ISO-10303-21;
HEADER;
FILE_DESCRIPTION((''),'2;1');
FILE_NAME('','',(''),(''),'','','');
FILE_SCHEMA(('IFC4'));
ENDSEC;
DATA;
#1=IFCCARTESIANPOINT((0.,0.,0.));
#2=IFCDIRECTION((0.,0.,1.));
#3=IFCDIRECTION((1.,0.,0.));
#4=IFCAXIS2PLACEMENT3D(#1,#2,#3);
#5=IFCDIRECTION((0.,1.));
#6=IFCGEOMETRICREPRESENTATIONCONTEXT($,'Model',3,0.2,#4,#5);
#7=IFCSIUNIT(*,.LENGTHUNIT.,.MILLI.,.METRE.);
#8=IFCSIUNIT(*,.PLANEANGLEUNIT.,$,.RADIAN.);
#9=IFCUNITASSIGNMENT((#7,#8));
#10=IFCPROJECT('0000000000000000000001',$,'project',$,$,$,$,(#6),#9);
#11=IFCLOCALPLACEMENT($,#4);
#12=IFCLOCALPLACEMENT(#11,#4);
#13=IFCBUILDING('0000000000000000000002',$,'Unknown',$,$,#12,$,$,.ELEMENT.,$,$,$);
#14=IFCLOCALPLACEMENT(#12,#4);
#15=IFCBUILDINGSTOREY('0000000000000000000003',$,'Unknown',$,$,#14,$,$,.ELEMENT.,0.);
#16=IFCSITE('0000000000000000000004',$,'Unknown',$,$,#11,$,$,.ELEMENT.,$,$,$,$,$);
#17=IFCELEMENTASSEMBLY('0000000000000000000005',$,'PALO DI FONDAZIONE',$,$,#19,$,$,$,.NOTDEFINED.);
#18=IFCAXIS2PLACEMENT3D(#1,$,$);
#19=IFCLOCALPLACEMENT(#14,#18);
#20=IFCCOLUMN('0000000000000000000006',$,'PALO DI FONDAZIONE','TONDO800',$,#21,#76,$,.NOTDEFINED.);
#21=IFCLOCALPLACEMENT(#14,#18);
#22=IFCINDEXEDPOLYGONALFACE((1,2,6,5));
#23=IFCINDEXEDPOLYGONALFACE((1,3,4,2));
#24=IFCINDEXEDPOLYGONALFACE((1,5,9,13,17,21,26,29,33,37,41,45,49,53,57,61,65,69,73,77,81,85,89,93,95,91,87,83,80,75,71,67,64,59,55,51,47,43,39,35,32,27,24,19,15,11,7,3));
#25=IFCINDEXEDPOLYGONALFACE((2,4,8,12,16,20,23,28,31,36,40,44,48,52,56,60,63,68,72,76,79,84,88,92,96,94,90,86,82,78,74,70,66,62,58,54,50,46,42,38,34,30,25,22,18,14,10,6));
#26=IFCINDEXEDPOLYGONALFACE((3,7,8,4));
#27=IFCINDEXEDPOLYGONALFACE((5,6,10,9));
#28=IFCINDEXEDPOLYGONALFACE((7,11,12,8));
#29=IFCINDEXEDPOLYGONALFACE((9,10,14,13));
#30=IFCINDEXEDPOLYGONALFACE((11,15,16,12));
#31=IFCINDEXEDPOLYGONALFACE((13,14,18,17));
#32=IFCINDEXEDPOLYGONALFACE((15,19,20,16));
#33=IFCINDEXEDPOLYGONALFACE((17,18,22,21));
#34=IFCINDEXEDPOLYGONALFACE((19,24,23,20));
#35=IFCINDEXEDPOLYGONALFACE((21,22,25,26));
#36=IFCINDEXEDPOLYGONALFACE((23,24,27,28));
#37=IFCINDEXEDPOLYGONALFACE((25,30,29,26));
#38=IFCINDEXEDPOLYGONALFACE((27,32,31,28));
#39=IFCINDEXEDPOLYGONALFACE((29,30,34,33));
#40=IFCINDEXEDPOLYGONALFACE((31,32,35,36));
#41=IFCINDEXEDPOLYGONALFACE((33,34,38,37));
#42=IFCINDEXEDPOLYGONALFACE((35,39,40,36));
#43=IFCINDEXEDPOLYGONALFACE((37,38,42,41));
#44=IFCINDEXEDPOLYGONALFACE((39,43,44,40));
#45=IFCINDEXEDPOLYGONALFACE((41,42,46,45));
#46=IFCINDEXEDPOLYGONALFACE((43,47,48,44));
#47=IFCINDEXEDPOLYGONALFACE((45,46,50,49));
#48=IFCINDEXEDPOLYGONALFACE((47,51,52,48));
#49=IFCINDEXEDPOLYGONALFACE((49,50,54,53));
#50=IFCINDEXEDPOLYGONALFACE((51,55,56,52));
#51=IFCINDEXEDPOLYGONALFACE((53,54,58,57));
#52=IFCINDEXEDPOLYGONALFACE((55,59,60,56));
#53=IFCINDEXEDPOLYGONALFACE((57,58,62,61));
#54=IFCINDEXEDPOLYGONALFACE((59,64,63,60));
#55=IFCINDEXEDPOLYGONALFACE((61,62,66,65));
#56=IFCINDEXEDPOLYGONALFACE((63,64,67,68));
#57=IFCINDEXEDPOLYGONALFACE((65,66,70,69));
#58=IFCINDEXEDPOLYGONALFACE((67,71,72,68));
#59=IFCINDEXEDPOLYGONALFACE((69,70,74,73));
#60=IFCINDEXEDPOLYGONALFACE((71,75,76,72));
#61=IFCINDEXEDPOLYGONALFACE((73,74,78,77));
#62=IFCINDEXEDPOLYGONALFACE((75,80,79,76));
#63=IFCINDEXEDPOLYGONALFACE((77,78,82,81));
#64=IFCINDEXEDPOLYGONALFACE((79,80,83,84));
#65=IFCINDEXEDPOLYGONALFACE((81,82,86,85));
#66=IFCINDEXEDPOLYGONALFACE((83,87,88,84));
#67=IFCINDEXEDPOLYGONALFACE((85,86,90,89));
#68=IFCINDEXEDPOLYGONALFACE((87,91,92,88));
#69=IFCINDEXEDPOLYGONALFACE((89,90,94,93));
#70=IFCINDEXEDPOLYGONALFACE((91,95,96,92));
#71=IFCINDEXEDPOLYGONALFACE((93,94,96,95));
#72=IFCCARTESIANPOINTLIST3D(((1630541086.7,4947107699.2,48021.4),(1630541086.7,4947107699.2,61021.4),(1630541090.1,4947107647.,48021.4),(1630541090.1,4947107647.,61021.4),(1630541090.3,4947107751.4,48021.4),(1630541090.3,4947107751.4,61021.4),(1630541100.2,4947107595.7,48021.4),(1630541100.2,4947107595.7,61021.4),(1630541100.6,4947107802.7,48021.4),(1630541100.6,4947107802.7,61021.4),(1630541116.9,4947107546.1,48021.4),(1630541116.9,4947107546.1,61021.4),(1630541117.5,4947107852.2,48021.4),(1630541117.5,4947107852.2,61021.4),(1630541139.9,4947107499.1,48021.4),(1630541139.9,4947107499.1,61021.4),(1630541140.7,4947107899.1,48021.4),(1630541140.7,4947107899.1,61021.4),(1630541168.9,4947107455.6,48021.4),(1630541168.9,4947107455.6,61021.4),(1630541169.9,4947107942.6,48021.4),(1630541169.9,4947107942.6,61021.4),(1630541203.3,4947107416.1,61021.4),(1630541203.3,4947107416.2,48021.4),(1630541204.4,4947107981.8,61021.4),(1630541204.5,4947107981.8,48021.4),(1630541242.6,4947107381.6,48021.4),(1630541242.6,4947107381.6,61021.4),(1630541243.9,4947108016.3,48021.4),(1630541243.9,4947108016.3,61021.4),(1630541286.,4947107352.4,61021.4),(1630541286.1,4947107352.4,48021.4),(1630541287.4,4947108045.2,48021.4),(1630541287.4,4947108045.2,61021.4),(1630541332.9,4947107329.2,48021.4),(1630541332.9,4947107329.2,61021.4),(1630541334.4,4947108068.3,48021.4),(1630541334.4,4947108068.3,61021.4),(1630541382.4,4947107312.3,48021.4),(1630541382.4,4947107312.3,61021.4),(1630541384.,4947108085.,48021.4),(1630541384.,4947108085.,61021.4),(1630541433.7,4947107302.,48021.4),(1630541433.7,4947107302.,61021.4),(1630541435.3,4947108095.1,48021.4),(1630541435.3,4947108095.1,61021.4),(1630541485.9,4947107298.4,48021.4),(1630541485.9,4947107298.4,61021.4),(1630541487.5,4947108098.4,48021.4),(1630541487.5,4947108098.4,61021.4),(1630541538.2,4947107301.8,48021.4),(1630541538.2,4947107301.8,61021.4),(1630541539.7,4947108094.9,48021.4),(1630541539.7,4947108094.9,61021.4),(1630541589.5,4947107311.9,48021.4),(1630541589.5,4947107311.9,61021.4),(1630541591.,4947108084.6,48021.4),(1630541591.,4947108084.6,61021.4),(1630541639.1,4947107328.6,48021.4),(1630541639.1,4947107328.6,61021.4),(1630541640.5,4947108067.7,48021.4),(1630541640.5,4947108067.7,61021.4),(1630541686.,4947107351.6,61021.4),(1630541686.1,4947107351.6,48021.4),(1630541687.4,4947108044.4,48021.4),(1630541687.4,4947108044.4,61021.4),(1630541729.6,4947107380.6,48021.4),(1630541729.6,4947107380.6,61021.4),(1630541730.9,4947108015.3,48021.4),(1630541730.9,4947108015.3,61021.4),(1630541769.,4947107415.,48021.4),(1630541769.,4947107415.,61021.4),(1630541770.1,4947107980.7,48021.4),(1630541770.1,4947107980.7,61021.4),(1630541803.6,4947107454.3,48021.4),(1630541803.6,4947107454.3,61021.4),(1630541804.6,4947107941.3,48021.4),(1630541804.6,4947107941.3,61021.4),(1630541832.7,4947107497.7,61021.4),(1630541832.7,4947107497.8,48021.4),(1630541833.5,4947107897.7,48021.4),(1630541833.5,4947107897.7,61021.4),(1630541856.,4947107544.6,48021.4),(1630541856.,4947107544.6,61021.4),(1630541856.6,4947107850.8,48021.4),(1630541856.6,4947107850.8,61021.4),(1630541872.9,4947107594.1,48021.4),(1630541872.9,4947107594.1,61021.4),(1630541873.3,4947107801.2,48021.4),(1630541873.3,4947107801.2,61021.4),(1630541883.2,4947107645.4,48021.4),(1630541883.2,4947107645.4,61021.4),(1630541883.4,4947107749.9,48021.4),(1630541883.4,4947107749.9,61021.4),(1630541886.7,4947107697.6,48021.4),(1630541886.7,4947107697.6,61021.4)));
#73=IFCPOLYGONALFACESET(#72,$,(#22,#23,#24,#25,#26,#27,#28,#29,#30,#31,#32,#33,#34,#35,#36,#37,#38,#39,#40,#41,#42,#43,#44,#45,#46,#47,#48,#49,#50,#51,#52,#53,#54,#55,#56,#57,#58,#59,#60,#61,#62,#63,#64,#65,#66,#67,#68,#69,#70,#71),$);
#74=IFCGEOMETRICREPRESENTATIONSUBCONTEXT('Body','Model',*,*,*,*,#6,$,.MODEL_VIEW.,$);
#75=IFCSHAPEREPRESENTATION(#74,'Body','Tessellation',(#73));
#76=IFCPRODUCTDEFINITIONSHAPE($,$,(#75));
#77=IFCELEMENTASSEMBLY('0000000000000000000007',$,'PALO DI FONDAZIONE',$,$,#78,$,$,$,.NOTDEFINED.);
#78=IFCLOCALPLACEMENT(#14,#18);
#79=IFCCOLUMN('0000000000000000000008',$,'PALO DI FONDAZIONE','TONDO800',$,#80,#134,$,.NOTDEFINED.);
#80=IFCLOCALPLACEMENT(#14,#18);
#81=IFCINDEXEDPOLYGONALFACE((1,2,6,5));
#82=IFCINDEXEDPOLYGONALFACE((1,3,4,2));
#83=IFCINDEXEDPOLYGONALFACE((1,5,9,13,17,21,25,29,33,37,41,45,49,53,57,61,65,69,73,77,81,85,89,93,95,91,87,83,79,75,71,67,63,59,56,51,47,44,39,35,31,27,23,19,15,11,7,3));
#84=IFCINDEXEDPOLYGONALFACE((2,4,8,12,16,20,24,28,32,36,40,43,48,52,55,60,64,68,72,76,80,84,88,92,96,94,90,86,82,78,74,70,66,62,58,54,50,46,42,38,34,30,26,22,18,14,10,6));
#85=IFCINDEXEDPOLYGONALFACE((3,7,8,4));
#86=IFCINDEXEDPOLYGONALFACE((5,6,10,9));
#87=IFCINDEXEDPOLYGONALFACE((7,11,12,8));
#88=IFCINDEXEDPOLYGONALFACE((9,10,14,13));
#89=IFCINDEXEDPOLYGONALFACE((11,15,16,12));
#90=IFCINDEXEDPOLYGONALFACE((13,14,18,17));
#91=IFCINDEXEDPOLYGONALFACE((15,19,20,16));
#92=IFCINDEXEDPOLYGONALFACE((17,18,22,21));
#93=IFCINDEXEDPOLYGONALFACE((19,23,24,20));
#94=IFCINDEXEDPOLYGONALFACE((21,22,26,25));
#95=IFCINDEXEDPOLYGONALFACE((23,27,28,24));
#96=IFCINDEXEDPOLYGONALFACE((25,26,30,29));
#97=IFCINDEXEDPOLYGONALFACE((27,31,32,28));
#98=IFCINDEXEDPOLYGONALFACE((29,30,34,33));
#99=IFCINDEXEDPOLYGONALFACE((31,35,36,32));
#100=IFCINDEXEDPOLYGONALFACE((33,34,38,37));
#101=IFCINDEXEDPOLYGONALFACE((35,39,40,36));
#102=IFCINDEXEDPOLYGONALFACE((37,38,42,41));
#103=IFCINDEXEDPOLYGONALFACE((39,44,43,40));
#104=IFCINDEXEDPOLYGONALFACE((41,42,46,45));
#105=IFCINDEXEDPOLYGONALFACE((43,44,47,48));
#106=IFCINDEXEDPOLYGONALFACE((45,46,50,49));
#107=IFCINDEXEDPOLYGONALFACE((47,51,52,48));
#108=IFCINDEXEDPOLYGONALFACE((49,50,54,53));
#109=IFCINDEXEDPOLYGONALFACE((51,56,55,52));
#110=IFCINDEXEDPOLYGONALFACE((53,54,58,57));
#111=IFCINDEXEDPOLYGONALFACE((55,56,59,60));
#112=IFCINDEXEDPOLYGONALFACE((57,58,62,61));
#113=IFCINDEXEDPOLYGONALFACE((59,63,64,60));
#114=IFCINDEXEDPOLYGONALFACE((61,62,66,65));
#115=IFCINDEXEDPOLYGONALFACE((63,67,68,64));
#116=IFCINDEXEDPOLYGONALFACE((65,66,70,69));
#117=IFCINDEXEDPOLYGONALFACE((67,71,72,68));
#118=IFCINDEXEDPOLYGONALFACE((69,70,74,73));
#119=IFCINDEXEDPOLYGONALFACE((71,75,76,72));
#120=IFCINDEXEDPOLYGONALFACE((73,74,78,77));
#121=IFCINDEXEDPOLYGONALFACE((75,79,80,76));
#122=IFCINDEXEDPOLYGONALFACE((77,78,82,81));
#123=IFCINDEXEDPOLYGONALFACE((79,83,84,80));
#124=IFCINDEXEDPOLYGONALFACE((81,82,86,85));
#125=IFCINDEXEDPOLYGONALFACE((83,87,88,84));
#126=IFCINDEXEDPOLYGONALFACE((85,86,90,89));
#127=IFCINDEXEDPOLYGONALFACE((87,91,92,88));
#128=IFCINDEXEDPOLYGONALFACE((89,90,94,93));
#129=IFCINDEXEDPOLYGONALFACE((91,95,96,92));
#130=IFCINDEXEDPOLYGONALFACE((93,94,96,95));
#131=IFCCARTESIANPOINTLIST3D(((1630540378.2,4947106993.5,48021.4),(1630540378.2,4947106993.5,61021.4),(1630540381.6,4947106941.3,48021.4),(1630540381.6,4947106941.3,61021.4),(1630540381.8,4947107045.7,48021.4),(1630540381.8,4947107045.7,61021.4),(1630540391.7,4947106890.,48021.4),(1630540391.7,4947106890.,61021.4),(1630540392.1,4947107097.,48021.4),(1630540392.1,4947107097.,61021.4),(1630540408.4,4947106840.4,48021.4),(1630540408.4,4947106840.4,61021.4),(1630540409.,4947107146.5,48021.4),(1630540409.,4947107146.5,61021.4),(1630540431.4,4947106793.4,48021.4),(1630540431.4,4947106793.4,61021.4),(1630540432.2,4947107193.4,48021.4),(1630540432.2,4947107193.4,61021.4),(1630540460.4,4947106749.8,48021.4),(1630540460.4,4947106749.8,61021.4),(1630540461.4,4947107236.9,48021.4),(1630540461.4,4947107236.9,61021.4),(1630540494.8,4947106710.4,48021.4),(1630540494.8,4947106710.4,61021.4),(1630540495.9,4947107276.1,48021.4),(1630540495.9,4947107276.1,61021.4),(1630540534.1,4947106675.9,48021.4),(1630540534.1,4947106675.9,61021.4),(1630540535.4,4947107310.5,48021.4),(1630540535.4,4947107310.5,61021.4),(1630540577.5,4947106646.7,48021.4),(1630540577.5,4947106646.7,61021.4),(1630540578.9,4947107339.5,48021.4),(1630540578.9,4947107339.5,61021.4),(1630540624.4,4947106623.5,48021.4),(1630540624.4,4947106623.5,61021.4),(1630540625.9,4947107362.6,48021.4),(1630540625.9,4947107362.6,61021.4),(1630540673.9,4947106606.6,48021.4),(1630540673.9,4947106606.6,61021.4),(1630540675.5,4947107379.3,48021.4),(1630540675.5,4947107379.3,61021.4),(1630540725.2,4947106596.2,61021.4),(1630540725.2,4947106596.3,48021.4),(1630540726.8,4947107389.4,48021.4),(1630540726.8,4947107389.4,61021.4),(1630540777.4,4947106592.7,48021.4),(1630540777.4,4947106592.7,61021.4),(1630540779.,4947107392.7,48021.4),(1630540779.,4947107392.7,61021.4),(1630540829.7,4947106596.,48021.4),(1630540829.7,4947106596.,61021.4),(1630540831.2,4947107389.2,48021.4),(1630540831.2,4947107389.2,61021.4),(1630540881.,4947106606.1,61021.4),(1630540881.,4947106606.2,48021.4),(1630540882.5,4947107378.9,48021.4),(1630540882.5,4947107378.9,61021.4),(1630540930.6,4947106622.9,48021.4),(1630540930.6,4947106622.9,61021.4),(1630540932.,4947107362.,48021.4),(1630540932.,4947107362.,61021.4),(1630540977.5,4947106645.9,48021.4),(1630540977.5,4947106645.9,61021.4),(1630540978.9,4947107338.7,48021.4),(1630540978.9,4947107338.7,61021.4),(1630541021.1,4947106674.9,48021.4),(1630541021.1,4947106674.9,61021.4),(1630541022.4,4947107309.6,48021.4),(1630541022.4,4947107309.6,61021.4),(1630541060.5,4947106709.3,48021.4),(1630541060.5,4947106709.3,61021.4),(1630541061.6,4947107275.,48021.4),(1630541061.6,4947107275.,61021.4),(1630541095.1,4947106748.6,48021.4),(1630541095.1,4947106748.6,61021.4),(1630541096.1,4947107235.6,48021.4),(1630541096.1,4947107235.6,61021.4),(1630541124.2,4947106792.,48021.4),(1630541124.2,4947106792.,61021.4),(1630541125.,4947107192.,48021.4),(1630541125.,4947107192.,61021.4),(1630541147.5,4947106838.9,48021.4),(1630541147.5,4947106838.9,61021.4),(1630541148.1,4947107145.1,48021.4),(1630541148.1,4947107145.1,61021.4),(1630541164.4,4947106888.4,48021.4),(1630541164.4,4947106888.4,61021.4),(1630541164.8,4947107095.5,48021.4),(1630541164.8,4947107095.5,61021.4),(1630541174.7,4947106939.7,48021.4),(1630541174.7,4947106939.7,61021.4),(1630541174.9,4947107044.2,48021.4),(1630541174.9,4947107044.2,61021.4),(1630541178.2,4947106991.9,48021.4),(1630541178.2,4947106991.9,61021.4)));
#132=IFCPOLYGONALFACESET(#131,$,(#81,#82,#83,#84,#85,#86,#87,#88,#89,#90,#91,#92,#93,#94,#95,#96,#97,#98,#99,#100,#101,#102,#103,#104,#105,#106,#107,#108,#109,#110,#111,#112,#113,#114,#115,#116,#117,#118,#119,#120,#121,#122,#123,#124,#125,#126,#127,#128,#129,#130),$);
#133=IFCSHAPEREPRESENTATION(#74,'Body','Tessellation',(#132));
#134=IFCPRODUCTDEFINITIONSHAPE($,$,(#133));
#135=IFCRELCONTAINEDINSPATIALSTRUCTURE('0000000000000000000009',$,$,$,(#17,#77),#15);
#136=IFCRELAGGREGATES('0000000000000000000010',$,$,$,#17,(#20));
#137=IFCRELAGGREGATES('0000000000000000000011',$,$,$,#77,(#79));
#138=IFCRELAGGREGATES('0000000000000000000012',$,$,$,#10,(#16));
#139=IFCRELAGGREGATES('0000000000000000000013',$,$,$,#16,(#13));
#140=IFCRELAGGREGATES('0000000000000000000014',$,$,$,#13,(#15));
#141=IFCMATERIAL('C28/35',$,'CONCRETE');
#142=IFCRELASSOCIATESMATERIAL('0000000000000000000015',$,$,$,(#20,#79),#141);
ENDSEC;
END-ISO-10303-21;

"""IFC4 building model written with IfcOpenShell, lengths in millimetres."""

from ifc_helpers import new_model, si_unit, direction, frame, origin_with_axes, place, context, subcontext, project, spatial, line, indexed_curve, outline, extrude, material, element, aggregate, save


model = new_model("IFC4")

# Units and contexts
model_context = context("Model", 3, precision=0.2, world=origin_with_axes(), true_north=direction((0.0, 1.0)))
body_context = subcontext(model_context, "Body", "Model", "MODEL_VIEW")
ifc_project = project(units=[si_unit("LENGTHUNIT", "METRE", prefix="MILLI"), si_unit("PLANEANGLEUNIT", "RADIAN")], contexts=[model_context])

# Site, building, storey
site_placement = place(None, origin_with_axes())
site = spatial("IfcSite", under=ifc_project, at=site_placement, Name="Unknown", CompositionType="ELEMENT")
building_placement = place(site_placement, origin_with_axes())
building = spatial("IfcBuilding", under=site, at=building_placement, Name="Unknown", CompositionType="ELEMENT")
storey_placement = place(building_placement, origin_with_axes())
storey = spatial("IfcBuildingStorey", under=building, at=storey_placement, Name="Unknown", CompositionType="ELEMENT", Elevation=0.0)

# Element assemblies, columns
ifc_material_1 = material(Name="C28/35", Category="CONCRETE")
assembly_1_placement = place(storey_placement, frame((1630541486.7, 4947107698.4, 48021.4), z_axis=(0.705709, -0.708501, 0.0), x_axis=(0.0, 0.0, 1.0)))
assembly_1 = element("IfcElementAssembly", 1, at=assembly_1_placement, inside=storey, Name="PALO DI FONDAZIONE", PredefinedType="NOTDEFINED")
column_1_placement = place(assembly_1_placement, origin_with_axes())
column_1 = element("IfcColumn", 2, at=column_1_placement, material=ifc_material_1, Name="PALO DI FONDAZIONE", Description="TONDO800", PredefinedType="NOTDEFINED", context=body_context, shape_type="SolidModel", body=[
    extrude(outline(indexed_curve([(400.0, 0.0), (396.6, 52.2), (386.4, 103.5), (369.6, 153.1), (346.4, 200.0), (317.3, 243.5), (282.8, 282.8), (243.5, 317.3), (200.0, 346.4), (153.1, 369.6), (103.5, 386.4), (52.2, 396.6), (0.0, 400.0), (-52.2, 396.6), (-103.5, 386.4), (-153.1, 369.6), (-200.0, 346.4), (-243.5, 317.3), (-282.8, 282.8), (-317.3, 243.5), (-346.4, 200.0), (-369.6, 153.1), (-386.4, 103.5), (-396.6, 52.2), (-400.0, 0.0), (-396.6, -52.2), (-386.4, -103.5), (-369.6, -153.1), (-346.4, -200.0), (-317.3, -243.5), (-282.8, -282.8), (-243.5, -317.3), (-200.0, -346.4), (-153.1, -369.6), (-103.5, -386.4), (-52.2, -396.6), (0.0, -400.0), (52.2, -396.6), (103.5, -386.4), (153.1, -369.6), (200.0, -346.4), (243.5, -317.3), (282.8, -282.8), (317.3, -243.5), (346.4, -200.0), (369.6, -153.1), (386.4, -103.5), (396.6, -52.2)], segments=[line(1, 2, 3, 4, 5, 6, 7, 8, 9, 10, 11, 12, 13, 14, 15, 16, 17, 18, 19, 20, 21, 22, 23, 24, 25, 26, 27, 28, 29, 30, 31, 32, 33, 34, 35, 36, 37, 38, 39, 40, 41, 42, 43, 44, 45, 46, 47, 48, 1)])), frame((0.0, 0.0, 0.0), z_axis=(-1.0, 0.0, 0.0), x_axis=(0.0, 0.0, 1.0)), (0.0, 0.0, -1.0), 13000.0),
])
aggregate(assembly_1, [column_1])
assembly_2_placement = place(storey_placement, frame((1630540778.2, 4947106992.7, 48021.4), z_axis=(0.705709, -0.708501, 0.0), x_axis=(0.0, 0.0, 1.0)))
assembly_2 = element("IfcElementAssembly", 3, at=assembly_2_placement, inside=storey, Name="PALO DI FONDAZIONE", PredefinedType="NOTDEFINED")
column_2_placement = place(assembly_2_placement, origin_with_axes())
column_2 = element("IfcColumn", 4, at=column_2_placement, material=ifc_material_1, Name="PALO DI FONDAZIONE", Description="TONDO800", PredefinedType="NOTDEFINED", context=body_context, shape_type="SolidModel", body=[
    extrude(outline(indexed_curve([(400.0, 0.0), (396.6, 52.2), (386.4, 103.5), (369.6, 153.1), (346.4, 200.0), (317.3, 243.5), (282.8, 282.8), (243.5, 317.3), (200.0, 346.4), (153.1, 369.6), (103.5, 386.4), (52.2, 396.6), (0.0, 400.0), (-52.2, 396.6), (-103.5, 386.4), (-153.1, 369.6), (-200.0, 346.4), (-243.5, 317.3), (-282.8, 282.8), (-317.3, 243.5), (-346.4, 200.0), (-369.6, 153.1), (-386.4, 103.5), (-396.6, 52.2), (-400.0, 0.0), (-396.6, -52.2), (-386.4, -103.5), (-369.6, -153.1), (-346.4, -200.0), (-317.3, -243.5), (-282.8, -282.8), (-243.5, -317.3), (-200.0, -346.4), (-153.1, -369.6), (-103.5, -386.4), (-52.2, -396.6), (0.0, -400.0), (52.2, -396.6), (103.5, -386.4), (153.1, -369.6), (200.0, -346.4), (243.5, -317.3), (282.8, -282.8), (317.3, -243.5), (346.4, -200.0), (369.6, -153.1), (386.4, -103.5), (396.6, -52.2)], segments=[line(1, 2, 3, 4, 5, 6, 7, 8, 9, 10, 11, 12, 13, 14, 15, 16, 17, 18, 19, 20, 21, 22, 23, 24, 25, 26, 27, 28, 29, 30, 31, 32, 33, 34, 35, 36, 37, 38, 39, 40, 41, 42, 43, 44, 45, 46, 47, 48, 1)])), frame((0.0, 0.0, 0.0), z_axis=(-1.0, 0.0, 0.0), x_axis=(0.0, 0.0, 1.0)), (0.0, 0.0, -1.0), 13000.0),
])
aggregate(assembly_2, [column_2])

save(model, "model.ifc")
